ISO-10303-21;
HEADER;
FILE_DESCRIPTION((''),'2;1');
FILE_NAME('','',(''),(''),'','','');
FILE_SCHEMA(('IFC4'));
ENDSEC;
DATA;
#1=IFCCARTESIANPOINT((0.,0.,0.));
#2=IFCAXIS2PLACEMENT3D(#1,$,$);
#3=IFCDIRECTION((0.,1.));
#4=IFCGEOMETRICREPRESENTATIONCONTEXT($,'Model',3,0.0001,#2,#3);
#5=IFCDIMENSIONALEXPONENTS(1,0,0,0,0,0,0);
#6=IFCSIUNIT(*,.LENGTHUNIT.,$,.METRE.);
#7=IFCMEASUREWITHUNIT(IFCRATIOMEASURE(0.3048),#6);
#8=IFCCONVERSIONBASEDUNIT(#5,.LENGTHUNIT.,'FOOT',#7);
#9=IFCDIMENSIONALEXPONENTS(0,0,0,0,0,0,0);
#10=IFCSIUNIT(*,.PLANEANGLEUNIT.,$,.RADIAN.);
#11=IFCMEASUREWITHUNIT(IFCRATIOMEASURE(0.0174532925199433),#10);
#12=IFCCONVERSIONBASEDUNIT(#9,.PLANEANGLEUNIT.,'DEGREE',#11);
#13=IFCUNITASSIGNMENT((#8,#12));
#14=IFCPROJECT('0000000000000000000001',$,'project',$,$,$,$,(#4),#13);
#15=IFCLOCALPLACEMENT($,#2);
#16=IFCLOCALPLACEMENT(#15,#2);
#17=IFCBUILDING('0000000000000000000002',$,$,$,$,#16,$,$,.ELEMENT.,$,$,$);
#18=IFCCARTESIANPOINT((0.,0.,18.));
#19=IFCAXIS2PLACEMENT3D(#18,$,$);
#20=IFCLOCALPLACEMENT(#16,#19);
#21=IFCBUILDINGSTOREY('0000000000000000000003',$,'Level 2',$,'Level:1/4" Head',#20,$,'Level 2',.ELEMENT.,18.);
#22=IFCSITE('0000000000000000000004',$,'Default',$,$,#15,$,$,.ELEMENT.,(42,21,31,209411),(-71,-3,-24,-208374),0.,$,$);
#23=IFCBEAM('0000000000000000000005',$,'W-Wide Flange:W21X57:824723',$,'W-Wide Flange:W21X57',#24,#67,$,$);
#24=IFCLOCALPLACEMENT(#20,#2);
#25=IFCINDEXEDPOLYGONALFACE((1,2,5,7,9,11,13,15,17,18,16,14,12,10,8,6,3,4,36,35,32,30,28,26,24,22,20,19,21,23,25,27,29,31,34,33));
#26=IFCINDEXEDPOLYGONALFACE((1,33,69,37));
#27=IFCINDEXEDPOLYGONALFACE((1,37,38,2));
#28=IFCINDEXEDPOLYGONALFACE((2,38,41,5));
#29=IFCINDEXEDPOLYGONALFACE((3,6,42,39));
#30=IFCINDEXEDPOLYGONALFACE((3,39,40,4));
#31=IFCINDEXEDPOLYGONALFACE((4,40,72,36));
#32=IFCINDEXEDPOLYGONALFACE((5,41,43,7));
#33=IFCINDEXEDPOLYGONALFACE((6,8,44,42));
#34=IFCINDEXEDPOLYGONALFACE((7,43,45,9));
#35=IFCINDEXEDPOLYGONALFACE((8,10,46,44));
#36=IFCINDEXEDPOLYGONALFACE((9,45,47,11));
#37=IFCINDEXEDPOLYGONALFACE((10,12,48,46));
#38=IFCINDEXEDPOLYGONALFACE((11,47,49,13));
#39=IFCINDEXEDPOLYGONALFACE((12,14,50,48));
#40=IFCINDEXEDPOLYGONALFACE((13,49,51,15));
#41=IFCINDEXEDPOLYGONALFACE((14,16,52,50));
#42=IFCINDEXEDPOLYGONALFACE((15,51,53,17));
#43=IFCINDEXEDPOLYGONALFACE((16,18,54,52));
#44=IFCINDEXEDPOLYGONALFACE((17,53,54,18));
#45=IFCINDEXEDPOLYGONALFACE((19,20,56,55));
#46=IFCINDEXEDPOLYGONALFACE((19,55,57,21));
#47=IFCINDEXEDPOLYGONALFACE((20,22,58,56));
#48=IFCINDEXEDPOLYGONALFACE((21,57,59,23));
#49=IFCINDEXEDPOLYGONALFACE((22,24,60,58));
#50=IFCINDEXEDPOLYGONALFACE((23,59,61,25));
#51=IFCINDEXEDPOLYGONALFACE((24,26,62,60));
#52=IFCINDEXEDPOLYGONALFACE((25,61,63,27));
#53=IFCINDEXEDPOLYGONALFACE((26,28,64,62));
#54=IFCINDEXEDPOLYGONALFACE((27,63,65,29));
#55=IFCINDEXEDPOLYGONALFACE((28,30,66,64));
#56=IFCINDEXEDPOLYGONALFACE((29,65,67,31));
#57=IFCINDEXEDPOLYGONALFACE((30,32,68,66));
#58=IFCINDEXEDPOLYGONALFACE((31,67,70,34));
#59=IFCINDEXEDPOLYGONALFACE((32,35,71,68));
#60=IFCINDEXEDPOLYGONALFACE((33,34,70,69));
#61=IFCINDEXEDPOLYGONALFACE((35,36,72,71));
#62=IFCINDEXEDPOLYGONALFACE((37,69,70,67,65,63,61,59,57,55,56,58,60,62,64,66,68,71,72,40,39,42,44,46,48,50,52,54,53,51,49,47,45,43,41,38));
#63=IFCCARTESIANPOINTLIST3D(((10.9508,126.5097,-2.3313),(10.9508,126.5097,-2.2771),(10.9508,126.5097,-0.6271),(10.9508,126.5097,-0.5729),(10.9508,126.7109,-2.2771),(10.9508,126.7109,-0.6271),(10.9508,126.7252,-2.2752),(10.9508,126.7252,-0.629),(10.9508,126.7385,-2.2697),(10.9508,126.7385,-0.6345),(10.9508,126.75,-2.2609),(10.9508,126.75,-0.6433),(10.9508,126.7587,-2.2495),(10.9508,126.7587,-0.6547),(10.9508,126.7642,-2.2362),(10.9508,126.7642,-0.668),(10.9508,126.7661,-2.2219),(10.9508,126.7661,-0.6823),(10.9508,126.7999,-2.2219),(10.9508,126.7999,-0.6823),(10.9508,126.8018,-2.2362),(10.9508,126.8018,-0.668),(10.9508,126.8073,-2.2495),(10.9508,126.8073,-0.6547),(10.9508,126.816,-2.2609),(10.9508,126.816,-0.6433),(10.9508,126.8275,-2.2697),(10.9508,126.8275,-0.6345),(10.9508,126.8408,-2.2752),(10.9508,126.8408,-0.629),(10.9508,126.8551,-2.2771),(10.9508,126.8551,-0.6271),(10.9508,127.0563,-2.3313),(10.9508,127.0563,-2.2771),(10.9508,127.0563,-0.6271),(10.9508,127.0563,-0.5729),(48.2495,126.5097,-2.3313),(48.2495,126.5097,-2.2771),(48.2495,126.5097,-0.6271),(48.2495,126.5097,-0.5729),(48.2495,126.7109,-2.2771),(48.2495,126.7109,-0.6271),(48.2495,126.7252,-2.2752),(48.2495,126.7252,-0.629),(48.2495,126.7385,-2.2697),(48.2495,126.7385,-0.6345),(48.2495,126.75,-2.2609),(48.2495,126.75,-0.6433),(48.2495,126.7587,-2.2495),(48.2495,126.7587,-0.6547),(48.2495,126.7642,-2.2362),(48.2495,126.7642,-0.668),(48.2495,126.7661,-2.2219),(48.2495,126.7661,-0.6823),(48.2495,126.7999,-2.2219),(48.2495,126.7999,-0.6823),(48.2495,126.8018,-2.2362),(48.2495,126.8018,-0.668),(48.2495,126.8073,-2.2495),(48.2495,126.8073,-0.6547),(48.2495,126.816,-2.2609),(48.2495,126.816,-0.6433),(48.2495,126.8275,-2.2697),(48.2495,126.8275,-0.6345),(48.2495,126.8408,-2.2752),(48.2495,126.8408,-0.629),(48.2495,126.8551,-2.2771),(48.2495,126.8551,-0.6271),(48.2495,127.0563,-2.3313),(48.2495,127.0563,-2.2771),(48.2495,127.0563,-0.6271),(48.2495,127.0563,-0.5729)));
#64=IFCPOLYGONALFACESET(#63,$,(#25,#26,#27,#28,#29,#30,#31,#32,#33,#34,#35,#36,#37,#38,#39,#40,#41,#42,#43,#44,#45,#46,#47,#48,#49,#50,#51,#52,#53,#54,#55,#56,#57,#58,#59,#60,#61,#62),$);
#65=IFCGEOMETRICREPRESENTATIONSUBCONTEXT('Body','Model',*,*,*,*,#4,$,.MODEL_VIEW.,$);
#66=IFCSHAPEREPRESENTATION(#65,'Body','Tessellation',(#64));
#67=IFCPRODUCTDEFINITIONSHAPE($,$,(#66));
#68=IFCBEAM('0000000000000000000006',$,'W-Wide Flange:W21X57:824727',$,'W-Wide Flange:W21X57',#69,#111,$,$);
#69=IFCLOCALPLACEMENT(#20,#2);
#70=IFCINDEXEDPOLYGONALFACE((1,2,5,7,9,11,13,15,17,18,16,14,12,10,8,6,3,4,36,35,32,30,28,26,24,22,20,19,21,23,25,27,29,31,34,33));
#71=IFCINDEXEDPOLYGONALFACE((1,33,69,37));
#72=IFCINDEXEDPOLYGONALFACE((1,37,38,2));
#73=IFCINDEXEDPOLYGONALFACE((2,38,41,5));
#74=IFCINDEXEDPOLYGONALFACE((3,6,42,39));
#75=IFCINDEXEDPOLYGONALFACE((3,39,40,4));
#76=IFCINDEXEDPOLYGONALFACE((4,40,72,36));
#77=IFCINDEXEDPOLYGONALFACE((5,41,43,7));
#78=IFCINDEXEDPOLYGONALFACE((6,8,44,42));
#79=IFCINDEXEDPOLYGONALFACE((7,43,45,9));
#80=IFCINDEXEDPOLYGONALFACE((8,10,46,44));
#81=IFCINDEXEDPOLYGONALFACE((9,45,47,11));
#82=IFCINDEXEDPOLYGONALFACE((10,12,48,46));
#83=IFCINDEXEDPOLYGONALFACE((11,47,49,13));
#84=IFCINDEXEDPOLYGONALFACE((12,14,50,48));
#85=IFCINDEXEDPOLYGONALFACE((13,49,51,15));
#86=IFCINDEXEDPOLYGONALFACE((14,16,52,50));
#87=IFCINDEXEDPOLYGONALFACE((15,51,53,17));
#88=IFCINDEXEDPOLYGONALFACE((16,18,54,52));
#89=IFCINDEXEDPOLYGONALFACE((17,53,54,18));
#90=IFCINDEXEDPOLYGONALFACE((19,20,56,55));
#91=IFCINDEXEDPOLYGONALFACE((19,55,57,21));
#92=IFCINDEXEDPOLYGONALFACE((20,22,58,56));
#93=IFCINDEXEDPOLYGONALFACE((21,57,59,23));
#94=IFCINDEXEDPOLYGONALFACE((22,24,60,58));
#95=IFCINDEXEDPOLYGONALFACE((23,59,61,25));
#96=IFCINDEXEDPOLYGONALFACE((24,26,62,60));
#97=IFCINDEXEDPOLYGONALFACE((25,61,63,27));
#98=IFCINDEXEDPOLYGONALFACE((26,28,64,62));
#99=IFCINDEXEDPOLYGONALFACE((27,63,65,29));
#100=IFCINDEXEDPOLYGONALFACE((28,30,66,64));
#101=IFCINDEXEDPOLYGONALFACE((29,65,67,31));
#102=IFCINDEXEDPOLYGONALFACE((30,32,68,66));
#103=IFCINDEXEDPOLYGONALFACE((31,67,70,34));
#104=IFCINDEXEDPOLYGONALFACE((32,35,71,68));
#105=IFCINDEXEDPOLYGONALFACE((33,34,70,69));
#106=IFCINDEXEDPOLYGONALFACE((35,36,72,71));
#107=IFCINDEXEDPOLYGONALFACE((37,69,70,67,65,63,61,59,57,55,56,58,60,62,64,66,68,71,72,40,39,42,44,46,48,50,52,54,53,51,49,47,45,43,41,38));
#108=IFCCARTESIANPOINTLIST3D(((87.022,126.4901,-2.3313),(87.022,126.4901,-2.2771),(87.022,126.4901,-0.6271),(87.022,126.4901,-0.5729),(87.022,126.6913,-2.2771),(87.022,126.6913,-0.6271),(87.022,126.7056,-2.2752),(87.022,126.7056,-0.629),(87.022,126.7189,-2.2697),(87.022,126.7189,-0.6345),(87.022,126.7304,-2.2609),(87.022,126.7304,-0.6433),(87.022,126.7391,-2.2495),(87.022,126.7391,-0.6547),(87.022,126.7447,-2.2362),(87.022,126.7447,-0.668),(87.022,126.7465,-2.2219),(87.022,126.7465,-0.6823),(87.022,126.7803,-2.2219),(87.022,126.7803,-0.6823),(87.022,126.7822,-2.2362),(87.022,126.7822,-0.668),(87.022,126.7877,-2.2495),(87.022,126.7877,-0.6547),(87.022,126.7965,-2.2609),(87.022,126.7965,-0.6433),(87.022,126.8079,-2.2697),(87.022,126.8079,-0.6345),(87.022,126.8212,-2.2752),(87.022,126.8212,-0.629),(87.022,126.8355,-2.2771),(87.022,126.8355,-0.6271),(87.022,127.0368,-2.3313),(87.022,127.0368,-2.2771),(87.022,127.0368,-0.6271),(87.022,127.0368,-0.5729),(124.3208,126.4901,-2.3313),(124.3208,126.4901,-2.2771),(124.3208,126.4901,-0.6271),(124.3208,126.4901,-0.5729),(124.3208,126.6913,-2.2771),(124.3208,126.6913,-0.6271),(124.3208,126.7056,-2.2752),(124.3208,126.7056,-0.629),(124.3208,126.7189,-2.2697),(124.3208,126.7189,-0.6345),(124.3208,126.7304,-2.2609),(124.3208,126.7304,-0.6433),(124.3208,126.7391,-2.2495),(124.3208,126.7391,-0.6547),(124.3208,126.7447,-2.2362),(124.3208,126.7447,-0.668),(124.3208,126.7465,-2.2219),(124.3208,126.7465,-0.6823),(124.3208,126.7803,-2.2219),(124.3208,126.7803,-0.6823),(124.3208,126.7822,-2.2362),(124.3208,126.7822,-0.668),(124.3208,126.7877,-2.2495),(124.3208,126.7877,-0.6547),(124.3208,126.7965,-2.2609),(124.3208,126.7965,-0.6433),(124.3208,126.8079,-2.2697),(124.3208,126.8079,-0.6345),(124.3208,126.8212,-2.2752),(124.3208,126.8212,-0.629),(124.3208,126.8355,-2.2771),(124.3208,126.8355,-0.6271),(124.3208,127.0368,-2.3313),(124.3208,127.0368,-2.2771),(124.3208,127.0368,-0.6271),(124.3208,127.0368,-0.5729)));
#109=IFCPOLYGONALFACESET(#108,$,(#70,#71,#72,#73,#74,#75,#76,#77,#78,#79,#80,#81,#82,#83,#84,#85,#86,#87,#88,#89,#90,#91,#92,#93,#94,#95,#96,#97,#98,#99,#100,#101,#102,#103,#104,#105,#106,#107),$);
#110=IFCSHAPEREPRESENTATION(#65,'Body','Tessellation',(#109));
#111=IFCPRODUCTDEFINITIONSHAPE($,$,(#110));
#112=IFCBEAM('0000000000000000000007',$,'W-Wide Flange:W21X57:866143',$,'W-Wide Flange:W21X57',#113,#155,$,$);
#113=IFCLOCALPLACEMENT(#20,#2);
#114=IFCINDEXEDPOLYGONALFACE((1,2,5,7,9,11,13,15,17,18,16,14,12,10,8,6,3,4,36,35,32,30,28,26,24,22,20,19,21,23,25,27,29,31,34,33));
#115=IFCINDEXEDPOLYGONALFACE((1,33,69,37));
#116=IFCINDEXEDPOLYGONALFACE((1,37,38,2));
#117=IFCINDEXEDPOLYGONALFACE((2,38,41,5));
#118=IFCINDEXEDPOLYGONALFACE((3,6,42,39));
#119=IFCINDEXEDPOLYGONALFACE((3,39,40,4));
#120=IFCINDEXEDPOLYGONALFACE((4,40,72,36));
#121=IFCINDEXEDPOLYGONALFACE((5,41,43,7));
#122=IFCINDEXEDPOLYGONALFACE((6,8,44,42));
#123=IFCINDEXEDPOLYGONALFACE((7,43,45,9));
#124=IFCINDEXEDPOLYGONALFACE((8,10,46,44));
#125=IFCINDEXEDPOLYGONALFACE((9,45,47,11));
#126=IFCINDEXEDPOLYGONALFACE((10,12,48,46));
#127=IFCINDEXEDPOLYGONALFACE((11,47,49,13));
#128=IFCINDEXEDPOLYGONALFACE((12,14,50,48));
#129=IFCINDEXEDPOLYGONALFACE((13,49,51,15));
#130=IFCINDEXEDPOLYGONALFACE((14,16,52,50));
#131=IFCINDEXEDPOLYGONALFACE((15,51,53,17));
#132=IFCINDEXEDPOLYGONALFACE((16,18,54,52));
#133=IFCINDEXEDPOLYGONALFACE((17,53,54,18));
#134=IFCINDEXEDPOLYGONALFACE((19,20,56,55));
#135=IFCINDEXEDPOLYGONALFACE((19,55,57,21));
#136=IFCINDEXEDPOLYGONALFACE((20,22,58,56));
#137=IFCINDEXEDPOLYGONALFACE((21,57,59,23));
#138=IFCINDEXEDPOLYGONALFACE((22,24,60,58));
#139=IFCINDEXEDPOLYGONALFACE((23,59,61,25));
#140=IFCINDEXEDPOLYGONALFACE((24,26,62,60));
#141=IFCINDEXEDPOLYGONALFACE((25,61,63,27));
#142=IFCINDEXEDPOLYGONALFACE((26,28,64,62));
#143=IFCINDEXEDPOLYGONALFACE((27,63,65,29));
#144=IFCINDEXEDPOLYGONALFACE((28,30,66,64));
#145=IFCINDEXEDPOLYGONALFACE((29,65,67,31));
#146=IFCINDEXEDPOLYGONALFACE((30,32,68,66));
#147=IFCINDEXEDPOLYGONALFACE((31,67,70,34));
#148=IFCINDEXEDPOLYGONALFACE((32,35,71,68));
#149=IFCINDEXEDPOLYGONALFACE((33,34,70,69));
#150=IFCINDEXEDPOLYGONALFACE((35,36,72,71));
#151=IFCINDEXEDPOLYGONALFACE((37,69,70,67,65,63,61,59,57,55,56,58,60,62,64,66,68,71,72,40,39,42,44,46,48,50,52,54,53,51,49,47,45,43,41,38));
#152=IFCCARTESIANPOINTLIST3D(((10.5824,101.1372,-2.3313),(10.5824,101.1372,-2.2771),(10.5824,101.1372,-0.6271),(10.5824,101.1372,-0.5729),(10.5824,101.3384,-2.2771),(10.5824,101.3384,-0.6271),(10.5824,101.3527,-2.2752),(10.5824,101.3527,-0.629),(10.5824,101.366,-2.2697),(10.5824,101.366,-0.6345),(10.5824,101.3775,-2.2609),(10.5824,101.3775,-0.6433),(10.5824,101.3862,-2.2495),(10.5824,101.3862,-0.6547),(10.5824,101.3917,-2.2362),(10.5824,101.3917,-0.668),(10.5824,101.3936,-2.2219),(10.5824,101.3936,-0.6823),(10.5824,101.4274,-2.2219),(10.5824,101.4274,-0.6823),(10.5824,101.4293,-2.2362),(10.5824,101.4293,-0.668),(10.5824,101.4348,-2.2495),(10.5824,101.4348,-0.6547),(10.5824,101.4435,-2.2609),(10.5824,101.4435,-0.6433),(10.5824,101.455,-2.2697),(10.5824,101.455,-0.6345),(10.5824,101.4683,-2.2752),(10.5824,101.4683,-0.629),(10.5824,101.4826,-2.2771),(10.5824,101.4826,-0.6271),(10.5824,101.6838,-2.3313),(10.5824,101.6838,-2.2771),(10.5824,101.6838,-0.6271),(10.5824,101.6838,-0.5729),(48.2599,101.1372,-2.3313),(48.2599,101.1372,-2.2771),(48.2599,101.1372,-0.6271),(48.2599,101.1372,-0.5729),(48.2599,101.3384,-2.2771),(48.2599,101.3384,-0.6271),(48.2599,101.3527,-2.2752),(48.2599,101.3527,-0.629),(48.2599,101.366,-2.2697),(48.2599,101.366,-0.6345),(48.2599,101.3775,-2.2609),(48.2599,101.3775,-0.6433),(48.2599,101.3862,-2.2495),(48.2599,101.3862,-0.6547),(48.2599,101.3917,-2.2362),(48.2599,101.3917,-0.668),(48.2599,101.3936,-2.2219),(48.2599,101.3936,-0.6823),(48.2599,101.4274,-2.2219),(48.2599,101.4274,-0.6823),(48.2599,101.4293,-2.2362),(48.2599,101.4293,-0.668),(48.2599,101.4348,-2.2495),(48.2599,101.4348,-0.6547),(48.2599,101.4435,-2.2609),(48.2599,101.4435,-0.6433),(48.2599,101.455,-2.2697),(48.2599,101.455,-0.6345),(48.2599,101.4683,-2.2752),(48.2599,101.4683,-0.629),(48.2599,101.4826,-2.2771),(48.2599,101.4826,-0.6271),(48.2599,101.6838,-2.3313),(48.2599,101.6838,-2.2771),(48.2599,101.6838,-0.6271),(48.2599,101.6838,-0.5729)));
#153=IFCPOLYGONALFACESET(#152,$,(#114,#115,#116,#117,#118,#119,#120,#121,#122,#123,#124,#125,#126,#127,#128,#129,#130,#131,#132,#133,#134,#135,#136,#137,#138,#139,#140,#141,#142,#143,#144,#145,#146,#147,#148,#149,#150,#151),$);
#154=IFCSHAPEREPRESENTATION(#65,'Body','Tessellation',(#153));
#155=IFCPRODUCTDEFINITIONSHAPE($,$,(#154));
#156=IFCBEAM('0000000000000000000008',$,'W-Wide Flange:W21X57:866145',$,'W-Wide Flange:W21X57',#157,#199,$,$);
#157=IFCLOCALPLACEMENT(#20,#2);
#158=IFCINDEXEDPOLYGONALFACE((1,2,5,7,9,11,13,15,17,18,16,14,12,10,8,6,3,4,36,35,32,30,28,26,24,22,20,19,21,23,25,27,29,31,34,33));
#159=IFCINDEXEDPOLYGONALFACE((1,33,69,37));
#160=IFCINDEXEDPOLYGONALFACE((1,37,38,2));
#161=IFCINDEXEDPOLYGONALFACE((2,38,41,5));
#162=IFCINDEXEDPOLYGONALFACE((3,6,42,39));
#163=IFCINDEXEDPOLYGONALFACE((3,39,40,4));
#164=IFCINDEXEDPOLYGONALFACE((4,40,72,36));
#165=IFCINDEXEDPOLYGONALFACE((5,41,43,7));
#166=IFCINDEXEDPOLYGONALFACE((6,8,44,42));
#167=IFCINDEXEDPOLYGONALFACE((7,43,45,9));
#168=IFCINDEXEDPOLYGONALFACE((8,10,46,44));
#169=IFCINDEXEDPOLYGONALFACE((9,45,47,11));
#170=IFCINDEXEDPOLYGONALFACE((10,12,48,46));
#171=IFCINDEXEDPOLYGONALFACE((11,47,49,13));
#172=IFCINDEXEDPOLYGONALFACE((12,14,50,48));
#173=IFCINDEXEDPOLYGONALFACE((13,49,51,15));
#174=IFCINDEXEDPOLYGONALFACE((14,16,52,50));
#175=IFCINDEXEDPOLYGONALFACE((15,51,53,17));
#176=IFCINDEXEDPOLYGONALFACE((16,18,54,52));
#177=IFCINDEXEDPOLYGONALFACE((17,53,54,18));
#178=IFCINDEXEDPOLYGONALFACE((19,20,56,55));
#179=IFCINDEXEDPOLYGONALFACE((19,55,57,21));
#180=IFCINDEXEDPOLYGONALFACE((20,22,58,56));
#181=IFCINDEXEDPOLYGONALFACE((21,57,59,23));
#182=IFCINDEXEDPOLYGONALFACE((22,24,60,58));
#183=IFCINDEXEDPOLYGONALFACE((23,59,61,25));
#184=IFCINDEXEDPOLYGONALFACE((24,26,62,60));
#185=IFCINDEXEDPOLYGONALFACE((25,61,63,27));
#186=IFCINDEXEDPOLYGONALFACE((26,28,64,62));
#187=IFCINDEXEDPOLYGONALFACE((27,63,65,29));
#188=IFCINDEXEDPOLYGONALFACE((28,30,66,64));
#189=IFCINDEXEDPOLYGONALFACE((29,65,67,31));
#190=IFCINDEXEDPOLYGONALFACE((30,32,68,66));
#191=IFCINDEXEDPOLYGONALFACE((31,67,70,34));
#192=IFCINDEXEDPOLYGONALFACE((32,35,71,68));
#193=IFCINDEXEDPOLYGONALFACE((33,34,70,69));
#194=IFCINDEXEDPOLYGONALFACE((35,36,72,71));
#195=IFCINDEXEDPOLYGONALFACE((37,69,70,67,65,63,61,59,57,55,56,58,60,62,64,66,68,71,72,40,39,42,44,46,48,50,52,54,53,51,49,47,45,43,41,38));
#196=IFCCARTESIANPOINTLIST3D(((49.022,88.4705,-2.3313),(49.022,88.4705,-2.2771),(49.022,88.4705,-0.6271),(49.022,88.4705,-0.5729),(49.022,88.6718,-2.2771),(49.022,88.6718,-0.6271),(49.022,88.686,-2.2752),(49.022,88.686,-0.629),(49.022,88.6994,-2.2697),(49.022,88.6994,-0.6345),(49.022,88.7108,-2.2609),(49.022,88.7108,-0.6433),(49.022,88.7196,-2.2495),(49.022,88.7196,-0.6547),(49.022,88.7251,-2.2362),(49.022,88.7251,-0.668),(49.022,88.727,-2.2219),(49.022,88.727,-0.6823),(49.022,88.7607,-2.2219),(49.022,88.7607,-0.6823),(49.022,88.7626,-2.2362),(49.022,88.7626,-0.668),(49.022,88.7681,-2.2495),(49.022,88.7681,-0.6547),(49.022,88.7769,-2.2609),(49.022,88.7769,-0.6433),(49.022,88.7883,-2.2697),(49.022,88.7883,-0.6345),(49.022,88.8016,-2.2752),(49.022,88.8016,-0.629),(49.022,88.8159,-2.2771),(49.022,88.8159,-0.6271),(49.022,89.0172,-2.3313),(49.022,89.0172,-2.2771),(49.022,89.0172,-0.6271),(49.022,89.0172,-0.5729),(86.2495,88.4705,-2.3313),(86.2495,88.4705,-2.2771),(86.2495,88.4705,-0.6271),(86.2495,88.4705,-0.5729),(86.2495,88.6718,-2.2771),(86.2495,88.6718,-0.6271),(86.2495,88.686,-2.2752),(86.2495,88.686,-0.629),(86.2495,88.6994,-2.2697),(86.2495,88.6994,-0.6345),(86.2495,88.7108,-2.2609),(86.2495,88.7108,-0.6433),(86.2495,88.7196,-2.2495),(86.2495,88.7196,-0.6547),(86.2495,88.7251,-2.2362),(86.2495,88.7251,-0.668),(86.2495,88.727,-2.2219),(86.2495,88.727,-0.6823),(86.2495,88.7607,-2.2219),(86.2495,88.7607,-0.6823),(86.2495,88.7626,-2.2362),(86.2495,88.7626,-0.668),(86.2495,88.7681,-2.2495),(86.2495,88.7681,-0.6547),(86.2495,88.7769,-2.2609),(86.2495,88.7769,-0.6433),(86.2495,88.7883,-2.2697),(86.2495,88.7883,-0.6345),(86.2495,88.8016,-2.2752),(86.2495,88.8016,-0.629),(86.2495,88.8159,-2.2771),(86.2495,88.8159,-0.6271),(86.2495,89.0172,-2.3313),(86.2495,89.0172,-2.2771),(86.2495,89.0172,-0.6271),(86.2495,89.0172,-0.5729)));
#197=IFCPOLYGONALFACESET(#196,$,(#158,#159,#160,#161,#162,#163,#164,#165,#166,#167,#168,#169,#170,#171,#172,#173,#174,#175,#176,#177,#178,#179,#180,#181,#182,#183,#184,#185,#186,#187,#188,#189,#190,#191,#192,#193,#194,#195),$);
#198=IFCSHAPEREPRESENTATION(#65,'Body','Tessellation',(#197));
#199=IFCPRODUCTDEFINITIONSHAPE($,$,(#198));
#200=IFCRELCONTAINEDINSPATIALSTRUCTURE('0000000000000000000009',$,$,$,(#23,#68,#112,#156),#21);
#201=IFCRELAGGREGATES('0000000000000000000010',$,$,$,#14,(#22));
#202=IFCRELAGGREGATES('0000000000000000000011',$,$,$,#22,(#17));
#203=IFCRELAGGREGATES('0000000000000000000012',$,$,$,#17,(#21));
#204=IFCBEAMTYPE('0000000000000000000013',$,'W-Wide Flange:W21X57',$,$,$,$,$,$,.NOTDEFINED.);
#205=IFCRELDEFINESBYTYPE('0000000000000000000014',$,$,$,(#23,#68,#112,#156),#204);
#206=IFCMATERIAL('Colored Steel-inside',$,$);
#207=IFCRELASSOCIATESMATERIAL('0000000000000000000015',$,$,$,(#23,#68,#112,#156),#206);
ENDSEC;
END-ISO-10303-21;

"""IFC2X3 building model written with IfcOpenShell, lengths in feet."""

from ifc_helpers import new_model, entity, si_unit, converted_unit, direction, frame, frame_2d, origin, place, context, subcontext, project, spatial, i_section, extrude, material, type_object, element, save


model = new_model("IFC2X3")

# Units and contexts
model_context = context("Model", 3, precision=0.0001, world=origin(), true_north=direction((0.0, 1.0)))
body_context = subcontext(model_context, "Body", "Model", "MODEL_VIEW")
ifc_project = project(units=[converted_unit("LENGTHUNIT", "FOOT", entity("IfcRatioMeasure", 0.3048), si_unit("LENGTHUNIT", "METRE"), dimensions=[1, 0, 0, 0, 0, 0, 0]), converted_unit("PLANEANGLEUNIT", "DEGREE", entity("IfcRatioMeasure", 0.0174532925199433), si_unit("PLANEANGLEUNIT", "RADIAN"), dimensions=[0, 0, 0, 0, 0, 0, 0])], contexts=[model_context])

# Site, building, storey
site_placement = place(None, origin())
site = spatial("IfcSite", under=ifc_project, at=site_placement, Name="Default", CompositionType="ELEMENT", RefLatitude=(42, 21, 31, 209411), RefLongitude=(-71, -3, -24, -208374), RefElevation=0.0)
building_placement = place(site_placement, origin())
building = spatial("IfcBuilding", under=site, at=building_placement, CompositionType="ELEMENT")
storey_placement = place(building_placement, frame((0.0, 0.0, 18.0)))
storey = spatial("IfcBuildingStorey", under=building, at=storey_placement, Name="Level 2", ObjectType="Level:1/4\" Head", LongName="Level 2", CompositionType="ELEMENT", Elevation=18.0)

# Shared definitions
ifc_material_1 = material(Name="Colored Steel-inside")

# Beams
beam_type_1 = type_object("IfcBeamType", Name="W-Wide Flange:W21X57", PredefinedType="NOTDEFINED")
beam_1_placement = place(storey_placement, frame((10.6358, 126.783, 0.0)))
element("IfcBeam", 1, at=beam_1_placement, inside=storey, type_object=beam_type_1, material=ifc_material_1, Name="W-Wide Flange:W21X57:824723", ObjectType="W-Wide Flange:W21X57", context=body_context, shape_type="SweptSolid", body=[
    extrude(i_section(OverallWidth=0.5467, OverallDepth=1.7583, WebThickness=0.0337, FlangeThickness=0.0542, FilletRadius=0.0552, at=frame_2d((0.0, 0.0), x_axis=(0.0, 1.0))), frame((0.315, 0.0, -1.4521), z_axis=(1.0, 0.0, 0.0), x_axis=(0.0, 0.0, -1.0)), (0.0, 0.0, 1.0), 37.2988),
])
beam_2_placement = place(storey_placement, frame((86.6358, 126.7634, 0.0)))
element("IfcBeam", 2, at=beam_2_placement, inside=storey, type_object=beam_type_1, material=ifc_material_1, Name="W-Wide Flange:W21X57:824727", ObjectType="W-Wide Flange:W21X57", context=body_context, shape_type="SweptSolid", body=[
    extrude(i_section(OverallWidth=0.5467, OverallDepth=1.7583, WebThickness=0.0337, FlangeThickness=0.0542, FilletRadius=0.0552, at=frame_2d((0.0, 0.0), x_axis=(0.0, 1.0))), frame((0.3862, 0.0, -1.4521), z_axis=(1.0, 0.0, 0.0), x_axis=(0.0, 0.0, -1.0)), (0.0, 0.0, 1.0), 37.2987),
])
beam_3_placement = place(storey_placement, frame((49.6554, 101.4105, 0.0), z_axis=(0.0, 0.0, 1.0), x_axis=(-1.0, 0.0, 0.0)))
element("IfcBeam", 3, at=beam_3_placement, inside=storey, type_object=beam_type_1, material=ifc_material_1, Name="W-Wide Flange:W21X57:866143", ObjectType="W-Wide Flange:W21X57", context=body_context, shape_type="SweptSolid", body=[
    extrude(i_section(OverallWidth=0.5467, OverallDepth=1.7583, WebThickness=0.0337, FlangeThickness=0.0542, FilletRadius=0.0552, at=frame_2d((0.0, 0.0), x_axis=(0.0, 1.0))), frame((1.3954, 0.0, -1.4521), z_axis=(1.0, 0.0, 0.0), x_axis=(0.0, 0.0, -1.0)), (0.0, 0.0, 1.0), 37.6775),
])
beam_4_placement = place(storey_placement, frame((48.6554, 88.7438, 0.0)))
element("IfcBeam", 4, at=beam_4_placement, inside=storey, type_object=beam_type_1, material=ifc_material_1, Name="W-Wide Flange:W21X57:866145", ObjectType="W-Wide Flange:W21X57", context=body_context, shape_type="SweptSolid", body=[
    extrude(i_section(OverallWidth=0.5467, OverallDepth=1.7583, WebThickness=0.0337, FlangeThickness=0.0542, FilletRadius=0.0552, at=frame_2d((0.0, 0.0), x_axis=(0.0, 1.0))), frame((0.3667, 0.0, -1.4521), z_axis=(1.0, 0.0, 0.0), x_axis=(0.0, 0.0, -1.0)), (0.0, 0.0, 1.0), 37.2275),
])

save(model, "model.ifc")
